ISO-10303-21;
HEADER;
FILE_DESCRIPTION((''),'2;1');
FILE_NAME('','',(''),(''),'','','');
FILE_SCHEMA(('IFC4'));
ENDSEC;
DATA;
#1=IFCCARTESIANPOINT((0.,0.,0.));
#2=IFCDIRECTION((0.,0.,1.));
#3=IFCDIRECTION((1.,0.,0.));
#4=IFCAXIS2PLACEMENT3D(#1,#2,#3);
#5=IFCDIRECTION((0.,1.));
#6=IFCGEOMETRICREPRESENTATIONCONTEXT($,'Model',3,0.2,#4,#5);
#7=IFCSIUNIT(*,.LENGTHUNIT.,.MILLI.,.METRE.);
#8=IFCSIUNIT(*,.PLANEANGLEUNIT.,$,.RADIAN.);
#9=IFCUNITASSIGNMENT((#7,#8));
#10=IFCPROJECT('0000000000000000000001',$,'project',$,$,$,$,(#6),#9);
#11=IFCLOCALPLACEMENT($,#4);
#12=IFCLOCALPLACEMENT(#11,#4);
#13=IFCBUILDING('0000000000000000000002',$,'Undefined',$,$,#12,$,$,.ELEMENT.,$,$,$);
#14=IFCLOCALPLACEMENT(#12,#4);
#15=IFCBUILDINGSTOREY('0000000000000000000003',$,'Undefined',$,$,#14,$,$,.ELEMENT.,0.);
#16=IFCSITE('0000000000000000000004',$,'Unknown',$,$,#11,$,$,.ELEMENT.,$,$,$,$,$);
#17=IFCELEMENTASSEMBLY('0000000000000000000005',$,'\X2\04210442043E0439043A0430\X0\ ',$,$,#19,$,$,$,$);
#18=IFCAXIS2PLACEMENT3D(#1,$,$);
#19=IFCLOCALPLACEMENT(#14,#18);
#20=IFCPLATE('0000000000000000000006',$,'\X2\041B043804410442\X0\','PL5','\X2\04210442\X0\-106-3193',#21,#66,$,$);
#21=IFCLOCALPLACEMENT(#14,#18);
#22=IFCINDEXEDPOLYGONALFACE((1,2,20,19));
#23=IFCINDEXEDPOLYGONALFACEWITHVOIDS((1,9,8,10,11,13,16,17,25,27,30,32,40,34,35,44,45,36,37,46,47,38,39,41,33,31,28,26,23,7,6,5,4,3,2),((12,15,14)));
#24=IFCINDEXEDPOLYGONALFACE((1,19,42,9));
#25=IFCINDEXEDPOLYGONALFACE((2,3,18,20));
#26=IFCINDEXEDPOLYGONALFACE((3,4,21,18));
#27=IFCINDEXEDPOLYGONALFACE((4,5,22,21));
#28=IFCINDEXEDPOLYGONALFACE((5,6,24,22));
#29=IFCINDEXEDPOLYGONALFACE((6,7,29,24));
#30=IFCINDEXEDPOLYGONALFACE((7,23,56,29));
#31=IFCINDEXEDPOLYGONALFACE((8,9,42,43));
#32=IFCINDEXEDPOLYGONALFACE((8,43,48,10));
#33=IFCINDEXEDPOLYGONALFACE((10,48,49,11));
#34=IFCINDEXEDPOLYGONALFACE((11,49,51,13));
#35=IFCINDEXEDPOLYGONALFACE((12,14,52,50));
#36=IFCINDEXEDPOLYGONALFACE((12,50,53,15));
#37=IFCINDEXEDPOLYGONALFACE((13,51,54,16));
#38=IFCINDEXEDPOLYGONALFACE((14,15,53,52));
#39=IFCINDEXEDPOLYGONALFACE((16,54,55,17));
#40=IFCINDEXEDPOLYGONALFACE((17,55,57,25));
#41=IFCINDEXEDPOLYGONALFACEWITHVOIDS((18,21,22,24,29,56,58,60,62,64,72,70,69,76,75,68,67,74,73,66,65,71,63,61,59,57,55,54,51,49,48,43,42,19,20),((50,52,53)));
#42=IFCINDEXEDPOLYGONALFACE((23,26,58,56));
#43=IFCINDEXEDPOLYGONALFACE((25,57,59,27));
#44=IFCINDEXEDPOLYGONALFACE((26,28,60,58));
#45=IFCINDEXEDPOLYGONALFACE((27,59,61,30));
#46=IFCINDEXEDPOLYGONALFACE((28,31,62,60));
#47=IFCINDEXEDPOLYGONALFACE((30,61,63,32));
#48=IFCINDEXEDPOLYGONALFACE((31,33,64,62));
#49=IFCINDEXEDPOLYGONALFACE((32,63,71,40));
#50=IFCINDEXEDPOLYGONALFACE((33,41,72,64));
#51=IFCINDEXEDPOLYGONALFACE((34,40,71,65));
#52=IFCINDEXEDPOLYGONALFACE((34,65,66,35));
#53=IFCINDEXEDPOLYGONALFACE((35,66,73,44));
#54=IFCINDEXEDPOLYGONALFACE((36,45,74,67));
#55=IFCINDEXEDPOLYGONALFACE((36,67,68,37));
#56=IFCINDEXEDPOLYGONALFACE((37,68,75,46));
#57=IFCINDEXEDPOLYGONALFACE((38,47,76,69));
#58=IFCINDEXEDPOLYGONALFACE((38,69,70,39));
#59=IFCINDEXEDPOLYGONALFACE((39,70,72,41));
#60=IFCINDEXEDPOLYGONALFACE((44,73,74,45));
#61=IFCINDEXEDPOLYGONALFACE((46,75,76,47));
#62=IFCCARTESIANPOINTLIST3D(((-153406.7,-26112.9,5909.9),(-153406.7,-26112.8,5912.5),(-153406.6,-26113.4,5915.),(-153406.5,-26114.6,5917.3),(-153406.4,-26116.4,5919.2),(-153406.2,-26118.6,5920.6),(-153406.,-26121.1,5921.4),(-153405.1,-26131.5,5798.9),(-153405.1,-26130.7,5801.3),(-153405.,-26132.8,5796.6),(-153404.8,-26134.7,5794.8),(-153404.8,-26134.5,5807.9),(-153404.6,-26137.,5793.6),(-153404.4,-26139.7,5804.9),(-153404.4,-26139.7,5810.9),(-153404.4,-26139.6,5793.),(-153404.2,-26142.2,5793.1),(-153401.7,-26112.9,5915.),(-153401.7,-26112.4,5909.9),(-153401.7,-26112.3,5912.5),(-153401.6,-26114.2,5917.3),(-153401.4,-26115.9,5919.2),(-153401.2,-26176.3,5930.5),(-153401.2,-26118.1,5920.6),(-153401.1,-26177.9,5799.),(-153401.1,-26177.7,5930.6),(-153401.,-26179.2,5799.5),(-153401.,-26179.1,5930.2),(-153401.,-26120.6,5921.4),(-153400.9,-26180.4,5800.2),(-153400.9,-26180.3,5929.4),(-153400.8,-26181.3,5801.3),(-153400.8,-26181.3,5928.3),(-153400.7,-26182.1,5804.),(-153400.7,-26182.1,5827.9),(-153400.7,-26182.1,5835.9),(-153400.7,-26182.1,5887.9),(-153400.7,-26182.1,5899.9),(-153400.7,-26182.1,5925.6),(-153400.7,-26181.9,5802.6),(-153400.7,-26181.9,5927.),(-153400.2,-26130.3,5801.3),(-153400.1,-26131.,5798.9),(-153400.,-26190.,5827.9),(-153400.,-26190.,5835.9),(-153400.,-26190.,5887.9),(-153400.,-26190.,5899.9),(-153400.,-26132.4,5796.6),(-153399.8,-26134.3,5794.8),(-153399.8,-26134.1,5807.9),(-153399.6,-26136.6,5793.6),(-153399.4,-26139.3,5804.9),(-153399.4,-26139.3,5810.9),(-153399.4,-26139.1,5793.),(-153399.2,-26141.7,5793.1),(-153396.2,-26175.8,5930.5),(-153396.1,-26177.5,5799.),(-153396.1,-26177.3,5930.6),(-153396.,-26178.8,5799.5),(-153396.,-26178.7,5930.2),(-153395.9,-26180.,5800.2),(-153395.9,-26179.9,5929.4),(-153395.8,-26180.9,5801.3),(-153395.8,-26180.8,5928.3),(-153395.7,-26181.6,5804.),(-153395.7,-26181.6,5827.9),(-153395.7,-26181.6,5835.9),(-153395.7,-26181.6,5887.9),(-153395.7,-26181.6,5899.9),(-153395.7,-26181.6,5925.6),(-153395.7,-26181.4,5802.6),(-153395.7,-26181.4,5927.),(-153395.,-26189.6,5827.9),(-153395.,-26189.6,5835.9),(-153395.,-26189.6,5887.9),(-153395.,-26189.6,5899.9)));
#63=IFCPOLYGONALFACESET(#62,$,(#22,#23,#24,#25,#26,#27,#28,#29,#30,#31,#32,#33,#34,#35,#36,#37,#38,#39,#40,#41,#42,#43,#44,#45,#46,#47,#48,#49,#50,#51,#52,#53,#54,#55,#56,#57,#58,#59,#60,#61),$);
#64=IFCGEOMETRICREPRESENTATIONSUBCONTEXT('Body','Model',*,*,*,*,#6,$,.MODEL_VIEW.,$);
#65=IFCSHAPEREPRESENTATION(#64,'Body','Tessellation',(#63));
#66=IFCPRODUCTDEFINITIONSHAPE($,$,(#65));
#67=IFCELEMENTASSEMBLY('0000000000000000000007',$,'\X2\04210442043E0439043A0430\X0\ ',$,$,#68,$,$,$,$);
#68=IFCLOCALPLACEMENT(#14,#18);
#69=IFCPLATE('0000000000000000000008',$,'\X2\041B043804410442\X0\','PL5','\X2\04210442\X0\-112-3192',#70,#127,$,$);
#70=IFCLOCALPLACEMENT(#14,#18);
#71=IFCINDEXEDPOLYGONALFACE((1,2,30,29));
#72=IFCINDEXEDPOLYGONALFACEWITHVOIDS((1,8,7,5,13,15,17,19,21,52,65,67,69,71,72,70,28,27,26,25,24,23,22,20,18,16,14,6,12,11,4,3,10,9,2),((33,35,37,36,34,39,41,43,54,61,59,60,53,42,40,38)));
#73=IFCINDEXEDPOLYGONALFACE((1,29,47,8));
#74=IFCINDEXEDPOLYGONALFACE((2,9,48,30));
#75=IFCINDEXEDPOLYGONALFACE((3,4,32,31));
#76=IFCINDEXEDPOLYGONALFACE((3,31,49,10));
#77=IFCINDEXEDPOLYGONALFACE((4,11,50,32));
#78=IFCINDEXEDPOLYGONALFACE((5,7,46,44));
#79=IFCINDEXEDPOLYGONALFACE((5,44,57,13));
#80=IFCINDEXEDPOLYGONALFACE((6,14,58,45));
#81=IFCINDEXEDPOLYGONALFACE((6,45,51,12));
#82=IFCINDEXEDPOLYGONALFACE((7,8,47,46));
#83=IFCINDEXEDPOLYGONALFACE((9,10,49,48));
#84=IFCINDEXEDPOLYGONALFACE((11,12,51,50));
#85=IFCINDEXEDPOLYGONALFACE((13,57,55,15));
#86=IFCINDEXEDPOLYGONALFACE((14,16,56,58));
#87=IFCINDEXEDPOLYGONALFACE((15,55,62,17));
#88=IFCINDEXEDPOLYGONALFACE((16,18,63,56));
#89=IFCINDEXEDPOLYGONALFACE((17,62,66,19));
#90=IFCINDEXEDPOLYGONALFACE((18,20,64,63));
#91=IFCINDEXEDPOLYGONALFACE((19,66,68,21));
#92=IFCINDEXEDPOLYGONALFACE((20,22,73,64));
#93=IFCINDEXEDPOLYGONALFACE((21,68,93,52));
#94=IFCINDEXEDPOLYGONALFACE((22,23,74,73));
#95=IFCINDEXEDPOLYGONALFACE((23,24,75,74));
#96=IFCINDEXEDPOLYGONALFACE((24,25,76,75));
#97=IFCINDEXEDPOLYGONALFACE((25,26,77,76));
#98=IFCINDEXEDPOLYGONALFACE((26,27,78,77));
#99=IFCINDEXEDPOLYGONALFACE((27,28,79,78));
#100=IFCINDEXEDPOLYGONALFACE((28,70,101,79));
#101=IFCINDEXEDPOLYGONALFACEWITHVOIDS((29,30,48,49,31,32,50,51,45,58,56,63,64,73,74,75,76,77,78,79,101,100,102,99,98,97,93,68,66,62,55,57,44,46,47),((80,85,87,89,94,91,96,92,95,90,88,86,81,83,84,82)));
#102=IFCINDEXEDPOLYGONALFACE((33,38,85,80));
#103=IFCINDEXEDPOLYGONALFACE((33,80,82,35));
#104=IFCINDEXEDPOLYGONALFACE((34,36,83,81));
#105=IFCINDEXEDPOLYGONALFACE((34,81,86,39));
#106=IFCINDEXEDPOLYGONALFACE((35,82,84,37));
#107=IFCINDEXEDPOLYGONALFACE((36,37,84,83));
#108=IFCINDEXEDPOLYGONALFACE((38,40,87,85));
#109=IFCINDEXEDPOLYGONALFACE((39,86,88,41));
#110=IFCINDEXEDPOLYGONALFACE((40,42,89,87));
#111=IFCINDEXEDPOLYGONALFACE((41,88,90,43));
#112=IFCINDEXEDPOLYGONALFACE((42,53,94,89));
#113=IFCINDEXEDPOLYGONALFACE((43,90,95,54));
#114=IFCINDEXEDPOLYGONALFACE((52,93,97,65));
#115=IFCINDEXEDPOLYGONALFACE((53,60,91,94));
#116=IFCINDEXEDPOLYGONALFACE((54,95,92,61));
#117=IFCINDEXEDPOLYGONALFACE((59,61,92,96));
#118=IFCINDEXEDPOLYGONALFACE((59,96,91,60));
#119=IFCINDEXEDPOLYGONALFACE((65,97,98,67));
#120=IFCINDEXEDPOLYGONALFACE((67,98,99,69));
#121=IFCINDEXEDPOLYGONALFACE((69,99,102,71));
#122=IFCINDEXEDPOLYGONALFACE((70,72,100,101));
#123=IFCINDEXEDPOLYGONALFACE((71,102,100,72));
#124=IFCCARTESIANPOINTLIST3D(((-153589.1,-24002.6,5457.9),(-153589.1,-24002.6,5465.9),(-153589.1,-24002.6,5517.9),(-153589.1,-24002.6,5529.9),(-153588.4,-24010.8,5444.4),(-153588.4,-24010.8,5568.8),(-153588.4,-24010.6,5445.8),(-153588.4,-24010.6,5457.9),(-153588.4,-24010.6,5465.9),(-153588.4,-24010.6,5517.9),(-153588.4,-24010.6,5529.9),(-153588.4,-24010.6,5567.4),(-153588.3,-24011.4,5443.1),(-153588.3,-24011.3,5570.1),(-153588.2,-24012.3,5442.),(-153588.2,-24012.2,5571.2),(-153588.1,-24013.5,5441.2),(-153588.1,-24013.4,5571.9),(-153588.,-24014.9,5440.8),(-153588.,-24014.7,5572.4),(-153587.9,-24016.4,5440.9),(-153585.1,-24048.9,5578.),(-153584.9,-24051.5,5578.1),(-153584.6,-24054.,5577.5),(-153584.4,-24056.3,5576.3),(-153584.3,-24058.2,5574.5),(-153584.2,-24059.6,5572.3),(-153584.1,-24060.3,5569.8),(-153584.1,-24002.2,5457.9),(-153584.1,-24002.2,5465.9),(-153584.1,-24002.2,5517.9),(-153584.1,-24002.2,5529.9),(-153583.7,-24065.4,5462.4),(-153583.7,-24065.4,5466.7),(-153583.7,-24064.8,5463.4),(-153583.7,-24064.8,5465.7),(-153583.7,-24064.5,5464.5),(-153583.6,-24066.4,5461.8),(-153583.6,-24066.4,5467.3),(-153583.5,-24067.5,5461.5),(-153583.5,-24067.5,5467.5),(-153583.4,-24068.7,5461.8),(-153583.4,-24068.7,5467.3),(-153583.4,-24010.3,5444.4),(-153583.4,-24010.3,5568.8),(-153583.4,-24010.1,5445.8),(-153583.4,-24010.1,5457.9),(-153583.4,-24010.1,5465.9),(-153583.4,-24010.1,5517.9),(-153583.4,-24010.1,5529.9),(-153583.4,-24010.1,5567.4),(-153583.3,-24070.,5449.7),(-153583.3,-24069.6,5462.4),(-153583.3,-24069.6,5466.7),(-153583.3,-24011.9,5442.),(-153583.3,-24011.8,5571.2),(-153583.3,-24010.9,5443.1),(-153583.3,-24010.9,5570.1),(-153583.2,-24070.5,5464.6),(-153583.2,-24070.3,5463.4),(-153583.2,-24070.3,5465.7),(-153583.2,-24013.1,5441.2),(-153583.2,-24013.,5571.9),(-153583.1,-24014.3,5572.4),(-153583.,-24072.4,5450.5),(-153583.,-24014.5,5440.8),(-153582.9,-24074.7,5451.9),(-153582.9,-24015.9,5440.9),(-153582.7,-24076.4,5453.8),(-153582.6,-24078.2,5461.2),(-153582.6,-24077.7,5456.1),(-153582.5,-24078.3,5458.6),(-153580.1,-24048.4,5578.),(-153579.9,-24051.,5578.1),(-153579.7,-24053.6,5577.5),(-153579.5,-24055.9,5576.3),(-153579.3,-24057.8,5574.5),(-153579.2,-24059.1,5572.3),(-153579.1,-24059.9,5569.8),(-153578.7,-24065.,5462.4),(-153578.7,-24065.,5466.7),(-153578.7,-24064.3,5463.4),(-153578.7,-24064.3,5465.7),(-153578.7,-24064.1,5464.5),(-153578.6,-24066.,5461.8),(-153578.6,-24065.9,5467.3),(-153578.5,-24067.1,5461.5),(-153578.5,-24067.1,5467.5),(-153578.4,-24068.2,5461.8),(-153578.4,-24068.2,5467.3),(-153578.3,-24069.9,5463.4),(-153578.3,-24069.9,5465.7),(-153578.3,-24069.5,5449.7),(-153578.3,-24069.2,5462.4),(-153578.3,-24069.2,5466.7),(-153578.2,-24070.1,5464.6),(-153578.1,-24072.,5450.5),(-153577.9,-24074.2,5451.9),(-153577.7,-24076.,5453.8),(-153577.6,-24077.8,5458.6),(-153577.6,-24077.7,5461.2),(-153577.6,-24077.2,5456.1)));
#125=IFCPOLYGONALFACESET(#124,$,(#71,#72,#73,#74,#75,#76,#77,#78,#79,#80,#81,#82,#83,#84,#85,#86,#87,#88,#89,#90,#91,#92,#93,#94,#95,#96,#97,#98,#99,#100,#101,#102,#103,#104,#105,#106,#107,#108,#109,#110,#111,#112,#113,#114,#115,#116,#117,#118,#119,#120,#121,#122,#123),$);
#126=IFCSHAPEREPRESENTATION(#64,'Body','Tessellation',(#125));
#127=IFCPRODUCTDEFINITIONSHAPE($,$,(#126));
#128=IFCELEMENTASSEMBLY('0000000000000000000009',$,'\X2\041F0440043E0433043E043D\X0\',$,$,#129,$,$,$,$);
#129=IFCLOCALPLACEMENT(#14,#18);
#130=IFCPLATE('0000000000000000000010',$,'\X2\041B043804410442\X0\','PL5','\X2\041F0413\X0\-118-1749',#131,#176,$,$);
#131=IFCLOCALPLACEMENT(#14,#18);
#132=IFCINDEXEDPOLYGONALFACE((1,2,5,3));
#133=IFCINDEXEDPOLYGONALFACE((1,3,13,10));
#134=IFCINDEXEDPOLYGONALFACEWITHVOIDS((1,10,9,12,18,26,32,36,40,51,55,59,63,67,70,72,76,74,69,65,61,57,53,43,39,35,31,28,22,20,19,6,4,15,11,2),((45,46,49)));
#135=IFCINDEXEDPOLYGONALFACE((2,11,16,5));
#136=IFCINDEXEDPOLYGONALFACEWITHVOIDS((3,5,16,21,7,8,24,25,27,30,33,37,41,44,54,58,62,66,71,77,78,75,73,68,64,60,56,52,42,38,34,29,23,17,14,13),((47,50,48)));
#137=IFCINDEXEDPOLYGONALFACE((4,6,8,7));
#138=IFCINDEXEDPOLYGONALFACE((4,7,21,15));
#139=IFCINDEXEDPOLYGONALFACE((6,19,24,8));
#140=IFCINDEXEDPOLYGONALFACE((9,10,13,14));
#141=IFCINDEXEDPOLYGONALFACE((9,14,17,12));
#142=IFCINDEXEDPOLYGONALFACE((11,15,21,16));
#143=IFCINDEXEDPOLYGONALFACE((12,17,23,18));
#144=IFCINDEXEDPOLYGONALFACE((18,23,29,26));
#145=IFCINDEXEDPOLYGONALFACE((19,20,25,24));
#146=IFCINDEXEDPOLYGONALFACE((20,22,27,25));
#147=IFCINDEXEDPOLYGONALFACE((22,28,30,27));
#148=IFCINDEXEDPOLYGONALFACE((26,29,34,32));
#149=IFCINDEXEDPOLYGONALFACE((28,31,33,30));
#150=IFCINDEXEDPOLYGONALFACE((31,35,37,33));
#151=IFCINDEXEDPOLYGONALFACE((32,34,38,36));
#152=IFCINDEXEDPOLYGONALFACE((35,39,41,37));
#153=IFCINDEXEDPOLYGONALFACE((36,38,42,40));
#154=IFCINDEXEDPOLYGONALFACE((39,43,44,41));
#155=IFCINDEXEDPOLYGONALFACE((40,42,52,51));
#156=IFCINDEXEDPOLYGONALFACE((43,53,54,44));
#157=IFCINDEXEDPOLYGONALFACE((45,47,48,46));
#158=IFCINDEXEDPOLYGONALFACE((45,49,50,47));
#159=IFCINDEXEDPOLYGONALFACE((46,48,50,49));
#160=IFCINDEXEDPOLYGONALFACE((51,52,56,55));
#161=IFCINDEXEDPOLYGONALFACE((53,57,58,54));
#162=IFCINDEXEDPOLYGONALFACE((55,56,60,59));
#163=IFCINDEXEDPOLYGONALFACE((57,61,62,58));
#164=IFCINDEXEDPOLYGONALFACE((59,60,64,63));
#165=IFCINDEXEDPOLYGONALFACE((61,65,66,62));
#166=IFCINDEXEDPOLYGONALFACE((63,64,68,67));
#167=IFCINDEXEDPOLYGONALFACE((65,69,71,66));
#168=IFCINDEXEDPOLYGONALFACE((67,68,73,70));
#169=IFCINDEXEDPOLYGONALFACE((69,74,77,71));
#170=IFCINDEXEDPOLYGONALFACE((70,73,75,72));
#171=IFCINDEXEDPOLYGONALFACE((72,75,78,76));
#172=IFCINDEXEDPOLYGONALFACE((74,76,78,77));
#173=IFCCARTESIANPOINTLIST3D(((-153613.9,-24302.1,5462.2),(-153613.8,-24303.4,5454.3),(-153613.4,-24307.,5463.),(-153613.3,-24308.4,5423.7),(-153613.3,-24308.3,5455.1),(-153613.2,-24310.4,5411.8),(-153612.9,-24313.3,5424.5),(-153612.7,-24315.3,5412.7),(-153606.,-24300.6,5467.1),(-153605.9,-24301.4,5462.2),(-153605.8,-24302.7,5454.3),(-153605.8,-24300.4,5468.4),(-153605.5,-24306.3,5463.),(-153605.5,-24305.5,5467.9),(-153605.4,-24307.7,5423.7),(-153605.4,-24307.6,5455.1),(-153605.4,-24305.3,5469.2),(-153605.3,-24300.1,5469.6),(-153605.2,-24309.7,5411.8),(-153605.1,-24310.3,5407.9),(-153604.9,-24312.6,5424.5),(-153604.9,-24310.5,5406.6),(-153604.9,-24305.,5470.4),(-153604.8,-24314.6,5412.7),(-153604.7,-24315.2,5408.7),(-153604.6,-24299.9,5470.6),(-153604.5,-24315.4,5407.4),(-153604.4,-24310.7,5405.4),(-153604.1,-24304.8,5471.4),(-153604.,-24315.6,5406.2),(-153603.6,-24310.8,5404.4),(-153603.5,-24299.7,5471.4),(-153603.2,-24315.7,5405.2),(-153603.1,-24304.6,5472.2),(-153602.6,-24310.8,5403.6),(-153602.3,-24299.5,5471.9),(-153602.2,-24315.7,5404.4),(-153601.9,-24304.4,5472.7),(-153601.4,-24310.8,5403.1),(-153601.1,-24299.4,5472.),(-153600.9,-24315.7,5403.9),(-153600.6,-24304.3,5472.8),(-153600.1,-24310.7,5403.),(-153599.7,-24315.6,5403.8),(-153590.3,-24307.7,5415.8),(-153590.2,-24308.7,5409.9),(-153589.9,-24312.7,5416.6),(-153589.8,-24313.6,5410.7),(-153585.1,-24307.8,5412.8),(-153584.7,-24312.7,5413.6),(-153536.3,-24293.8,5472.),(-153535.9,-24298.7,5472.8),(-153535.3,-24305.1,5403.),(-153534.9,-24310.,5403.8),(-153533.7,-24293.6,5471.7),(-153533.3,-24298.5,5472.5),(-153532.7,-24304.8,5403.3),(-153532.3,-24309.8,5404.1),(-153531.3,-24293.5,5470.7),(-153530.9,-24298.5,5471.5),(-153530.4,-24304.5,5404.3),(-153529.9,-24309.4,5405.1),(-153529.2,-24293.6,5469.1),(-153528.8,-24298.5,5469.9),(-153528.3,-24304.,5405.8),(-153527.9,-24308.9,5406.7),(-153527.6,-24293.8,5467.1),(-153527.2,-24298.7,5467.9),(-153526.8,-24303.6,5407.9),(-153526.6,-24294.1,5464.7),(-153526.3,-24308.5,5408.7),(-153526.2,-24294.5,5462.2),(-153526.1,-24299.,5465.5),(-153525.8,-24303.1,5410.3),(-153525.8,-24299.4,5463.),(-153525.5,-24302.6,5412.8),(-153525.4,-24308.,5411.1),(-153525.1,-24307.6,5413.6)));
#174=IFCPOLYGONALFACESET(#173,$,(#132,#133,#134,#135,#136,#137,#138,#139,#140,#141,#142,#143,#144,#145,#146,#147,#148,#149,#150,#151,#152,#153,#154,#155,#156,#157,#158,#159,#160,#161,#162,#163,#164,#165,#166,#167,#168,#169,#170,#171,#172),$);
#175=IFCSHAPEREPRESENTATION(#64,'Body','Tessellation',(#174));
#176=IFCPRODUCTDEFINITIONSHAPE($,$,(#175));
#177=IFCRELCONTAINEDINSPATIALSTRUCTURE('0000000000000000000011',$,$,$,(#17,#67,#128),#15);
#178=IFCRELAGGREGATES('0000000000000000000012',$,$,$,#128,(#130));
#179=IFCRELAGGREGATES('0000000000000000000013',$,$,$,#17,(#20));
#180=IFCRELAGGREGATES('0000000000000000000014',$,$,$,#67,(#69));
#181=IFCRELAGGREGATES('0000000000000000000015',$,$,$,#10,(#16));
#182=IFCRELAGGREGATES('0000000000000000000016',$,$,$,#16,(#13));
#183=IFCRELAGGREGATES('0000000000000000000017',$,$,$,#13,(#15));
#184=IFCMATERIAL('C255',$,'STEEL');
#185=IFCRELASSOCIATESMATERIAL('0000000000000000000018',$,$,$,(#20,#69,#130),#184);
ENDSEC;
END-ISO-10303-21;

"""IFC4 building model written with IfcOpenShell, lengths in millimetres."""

from ifc_helpers import new_model, si_unit, direction, frame, origin_with_axes, place, context, subcontext, project, spatial, line, arc, indexed_curve, outline, extrude, material, element, aggregate, save


model = new_model("IFC4")

# Units and contexts
model_context = context("Model", 3, precision=0.2, world=origin_with_axes(), true_north=direction((0.0, 1.0)))
body_context = subcontext(model_context, "Body", "Model", "MODEL_VIEW")
ifc_project = project(units=[si_unit("LENGTHUNIT", "METRE", prefix="MILLI"), si_unit("PLANEANGLEUNIT", "RADIAN")], contexts=[model_context])

# Site, building, storey
site_placement = place(None, origin_with_axes())
site = spatial("IfcSite", under=ifc_project, at=site_placement, Name="Unknown", CompositionType="ELEMENT")
building_placement = place(site_placement, origin_with_axes())
building = spatial("IfcBuilding", under=site, at=building_placement, Name="Undefined", CompositionType="ELEMENT")
storey_placement = place(building_placement, origin_with_axes())
storey = spatial("IfcBuildingStorey", under=building, at=storey_placement, Name="Undefined", CompositionType="ELEMENT", Elevation=0.0)

# Shared definitions
ifc_material_1 = material(Name="C255", Category="STEEL")

# Element assembly, plate, voiding feature
assembly_1_placement = place(storey_placement, frame((-153388.9, -26231.4, 4198.4), z_axis=(-0.086114, 0.996285, 0.0), x_axis=(0.0, 0.0, 1.0)))
assembly_1 = element("IfcElementAssembly", 1, at=assembly_1_placement, inside=storey, Name="Стойка ")
plate_1_placement = place(assembly_1_placement, frame((1593.1, -5.0, 100.1), z_axis=(-0.000024, 1.0, 0.0), x_axis=(0.986646, 0.000024, 0.162881)))
plate_1 = element("IfcPlate", 2, at=plate_1_placement, material=ifc_material_1, Name="Лист", Description="PL5", ObjectType="Ст-106-3193", context=body_context, shape_type="SolidModel", body=[
    extrude(outline(indexed_curve([(0.0, 10.0), (2.9, 2.9), (10.0, 0.0), (120.0, 0.0), (127.1, 2.9), (130.0, 10.0), (130.0, 66.2), (128.2, 70.0), (124.2, 71.1), (98.8, 66.9), (97.5, 74.8), (85.7, 72.9), (87.0, 65.0), (35.7, 56.5), (34.4, 64.4), (26.5, 63.1), (27.8, 55.2), (4.2, 51.3), (1.2, 49.6), (0.0, 46.4)], segments=[arc(1, 2, 3), line(3, 4), arc(4, 5, 6), line(6, 7), arc(7, 8, 9), line(9, 10, 11, 12, 13, 14, 15, 16, 17, 18), arc(18, 19, 20), line(20, 1)])), frame((0.0, 0.0, 2.5), z_axis=(0.0, 0.0, 1.0), x_axis=(1.0, 0.0, 0.0)), (0.0, 0.0, -1.0), 5.0),
])
voiding_feature_1_placement = place(plate_1_placement, frame((15.0, 10.0, 10.0), z_axis=(0.165862, -0.986149, 0.0), x_axis=(0.0, 0.0, -1.0)))
element("IfcVoidingFeature", 3, at=voiding_feature_1_placement, cuts=plate_1, Name="Балка", ObjectType="(?)", PredefinedType="HOLE", context=body_context, shape_type="SolidModel", body=[
    extrude(outline(indexed_curve([(0.0, -3.0), (5.2, 0.0), (0.0, 3.0)], segments=[line(1, 2, 3, 1)])), frame((0.0, 0.0, 0.0), z_axis=(-1.0, 0.0, 0.0), x_axis=(0.0, 0.0, 1.0)), (0.0, 0.0, -1.0), 20.0),
])

# Element assemblies, plates, voiding features
assembly_2_placement = place(storey_placement, frame((-153594.3, -23970.7, 3672.5), z_axis=(-0.086114, 0.996285, 0.0), x_axis=(0.0, 0.0, 1.0)))
assembly_2 = element("IfcElementAssembly", 4, at=assembly_2_placement, inside=storey, Name="Стойка ")
plate_2_placement = place(assembly_2_placement, frame((1778.8, 5.0, -109.7), z_axis=(0.000023, -1.0, 0.000007), x_axis=(0.986646, 0.000024, 0.162881)))
plate_2 = element("IfcPlate", 5, at=plate_2_placement, material=ifc_material_1, Name="Лист", Description="PL5", ObjectType="Ст-112-3192", context=body_context, shape_type="SolidModel", body=[
    extrude(outline(indexed_curve([(0.0, 10.0), (2.9, 2.9), (10.0, 0.0), (120.0, 0.0), (127.1, 2.9), (130.0, 10.0), (130.0, 44.7), (128.8, 48.0), (125.8, 49.6), (88.8, 55.8), (90.1, 63.7), (78.2, 65.6), (76.9, 57.7), (25.6, 66.2), (26.9, 74.1), (19.0, 75.4), (17.7, 67.5), (5.8, 69.5), (1.8, 68.3), (0.0, 64.5)], segments=[arc(1, 2, 3), line(3, 4), arc(4, 5, 6), line(6, 7), arc(7, 8, 9), line(9, 10, 11, 12, 13, 14, 15, 16, 17, 18), arc(18, 19, 20), line(20, 1)])), frame((0.0, 0.0, 2.5), z_axis=(0.0, 0.0, 1.0), x_axis=(1.0, 0.0, 0.0)), (0.0, 0.0, -1.0), 5.0),
])
voiding_feature_2_placement = place(plate_2_placement, frame((15.0, 10.0, 10.0), z_axis=(-0.159897, -0.987134, 0.0), x_axis=(0.0, 0.0, -1.0)))
element("IfcVoidingFeature", 6, at=voiding_feature_2_placement, cuts=plate_2, Name="Балка", ObjectType="(?)", PredefinedType="HOLE", context=body_context, shape_type="SolidModel", body=[
    extrude(outline(indexed_curve([(3.0, 0.0), (2.8, 1.1), (2.1, 2.1), (1.1, 2.8), (0.0, 3.0), (-1.1, 2.8), (-2.1, 2.1), (-2.8, 1.1), (-3.0, 0.0), (-2.8, -1.1), (-2.1, -2.1), (-1.1, -2.8), (0.0, -3.0), (1.1, -2.8), (2.1, -2.1), (2.8, -1.1)], segments=[line(1, 2, 3, 4, 5, 6, 7, 8, 9, 10, 11, 12, 13, 14, 15, 16, 1)])), frame((0.0, 0.0, 0.0), z_axis=(-1.0, 0.0, 0.0), x_axis=(0.0, 0.0, 1.0)), (0.0, 0.0, -1.0), 20.0),
])
assembly_3_placement = place(storey_placement, frame((-153645.0, -24313.2, 3248.5), z_axis=(0.086114, -0.996285, 0.0), x_axis=(0.0, 0.0, 1.0)))
assembly_3 = element("IfcElementAssembly", 7, at=assembly_3_placement, inside=storey, Name="Прогон")
plate_3_placement = place(assembly_3_placement, frame((2223.9, -120.0, -7.5), z_axis=(-0.162881, -0.000054, -0.986646), x_axis=(-0.986646, 0.000078, 0.162881)))
plate_3 = element("IfcPlate", 8, at=plate_3_placement, material=ifc_material_1, Name="Лист", Description="PL5", ObjectType="ПГ-118-1749", context=body_context, shape_type="SolidModel", body=[
    extrude(outline(indexed_curve([(0.0, 10.0), (2.9, 2.9), (10.0, 0.0), (60.0, 0.0), (67.1, 2.9), (70.0, 10.0), (70.0, 75.0), (68.5, 78.5), (65.0, 80.0), (61.0, 80.0), (61.0, 88.0), (49.0, 88.0), (49.0, 80.0), (18.0, 80.0), (18.0, 88.0), (10.0, 88.0), (10.0, 80.0), (5.0, 80.0), (1.5, 78.5), (0.0, 75.0)], segments=[arc(1, 2, 3), line(3, 4), arc(4, 5, 6), line(6, 7), arc(7, 8, 9), line(9, 10, 11, 12, 13, 14, 15, 16, 17, 18), arc(18, 19, 20), line(20, 1)])), frame((0.0, 0.0, 2.5), z_axis=(0.0, 0.0, 1.0), x_axis=(1.0, 0.0, 0.0)), (0.0, 0.0, -1.0), 5.0),
])
voiding_feature_3_placement = place(plate_3_placement, frame((60.0, 65.0, 6.0), z_axis=(-0.000054, -1.0, 0.000034), x_axis=(0.0, -0.000034, -1.0)))
element("IfcVoidingFeature", 9, at=voiding_feature_3_placement, cuts=plate_3, Name="Балка", ObjectType="(?)", PredefinedType="HOLE", context=body_context, shape_type="SolidModel", body=[
    extrude(outline(indexed_curve([(0.0, -3.0), (5.2, 0.0), (0.0, 3.0)], segments=[line(1, 2, 3, 1)])), frame((0.0, 0.0, 0.0), z_axis=(-1.0, 0.0, 0.0), x_axis=(0.0, 0.0, 1.0)), (0.0, 0.0, -1.0), 12.0),
])

aggregate(assembly_3, [plate_3])
aggregate(assembly_1, [plate_1])
aggregate(assembly_2, [plate_2])

save(model, "model.ifc")
